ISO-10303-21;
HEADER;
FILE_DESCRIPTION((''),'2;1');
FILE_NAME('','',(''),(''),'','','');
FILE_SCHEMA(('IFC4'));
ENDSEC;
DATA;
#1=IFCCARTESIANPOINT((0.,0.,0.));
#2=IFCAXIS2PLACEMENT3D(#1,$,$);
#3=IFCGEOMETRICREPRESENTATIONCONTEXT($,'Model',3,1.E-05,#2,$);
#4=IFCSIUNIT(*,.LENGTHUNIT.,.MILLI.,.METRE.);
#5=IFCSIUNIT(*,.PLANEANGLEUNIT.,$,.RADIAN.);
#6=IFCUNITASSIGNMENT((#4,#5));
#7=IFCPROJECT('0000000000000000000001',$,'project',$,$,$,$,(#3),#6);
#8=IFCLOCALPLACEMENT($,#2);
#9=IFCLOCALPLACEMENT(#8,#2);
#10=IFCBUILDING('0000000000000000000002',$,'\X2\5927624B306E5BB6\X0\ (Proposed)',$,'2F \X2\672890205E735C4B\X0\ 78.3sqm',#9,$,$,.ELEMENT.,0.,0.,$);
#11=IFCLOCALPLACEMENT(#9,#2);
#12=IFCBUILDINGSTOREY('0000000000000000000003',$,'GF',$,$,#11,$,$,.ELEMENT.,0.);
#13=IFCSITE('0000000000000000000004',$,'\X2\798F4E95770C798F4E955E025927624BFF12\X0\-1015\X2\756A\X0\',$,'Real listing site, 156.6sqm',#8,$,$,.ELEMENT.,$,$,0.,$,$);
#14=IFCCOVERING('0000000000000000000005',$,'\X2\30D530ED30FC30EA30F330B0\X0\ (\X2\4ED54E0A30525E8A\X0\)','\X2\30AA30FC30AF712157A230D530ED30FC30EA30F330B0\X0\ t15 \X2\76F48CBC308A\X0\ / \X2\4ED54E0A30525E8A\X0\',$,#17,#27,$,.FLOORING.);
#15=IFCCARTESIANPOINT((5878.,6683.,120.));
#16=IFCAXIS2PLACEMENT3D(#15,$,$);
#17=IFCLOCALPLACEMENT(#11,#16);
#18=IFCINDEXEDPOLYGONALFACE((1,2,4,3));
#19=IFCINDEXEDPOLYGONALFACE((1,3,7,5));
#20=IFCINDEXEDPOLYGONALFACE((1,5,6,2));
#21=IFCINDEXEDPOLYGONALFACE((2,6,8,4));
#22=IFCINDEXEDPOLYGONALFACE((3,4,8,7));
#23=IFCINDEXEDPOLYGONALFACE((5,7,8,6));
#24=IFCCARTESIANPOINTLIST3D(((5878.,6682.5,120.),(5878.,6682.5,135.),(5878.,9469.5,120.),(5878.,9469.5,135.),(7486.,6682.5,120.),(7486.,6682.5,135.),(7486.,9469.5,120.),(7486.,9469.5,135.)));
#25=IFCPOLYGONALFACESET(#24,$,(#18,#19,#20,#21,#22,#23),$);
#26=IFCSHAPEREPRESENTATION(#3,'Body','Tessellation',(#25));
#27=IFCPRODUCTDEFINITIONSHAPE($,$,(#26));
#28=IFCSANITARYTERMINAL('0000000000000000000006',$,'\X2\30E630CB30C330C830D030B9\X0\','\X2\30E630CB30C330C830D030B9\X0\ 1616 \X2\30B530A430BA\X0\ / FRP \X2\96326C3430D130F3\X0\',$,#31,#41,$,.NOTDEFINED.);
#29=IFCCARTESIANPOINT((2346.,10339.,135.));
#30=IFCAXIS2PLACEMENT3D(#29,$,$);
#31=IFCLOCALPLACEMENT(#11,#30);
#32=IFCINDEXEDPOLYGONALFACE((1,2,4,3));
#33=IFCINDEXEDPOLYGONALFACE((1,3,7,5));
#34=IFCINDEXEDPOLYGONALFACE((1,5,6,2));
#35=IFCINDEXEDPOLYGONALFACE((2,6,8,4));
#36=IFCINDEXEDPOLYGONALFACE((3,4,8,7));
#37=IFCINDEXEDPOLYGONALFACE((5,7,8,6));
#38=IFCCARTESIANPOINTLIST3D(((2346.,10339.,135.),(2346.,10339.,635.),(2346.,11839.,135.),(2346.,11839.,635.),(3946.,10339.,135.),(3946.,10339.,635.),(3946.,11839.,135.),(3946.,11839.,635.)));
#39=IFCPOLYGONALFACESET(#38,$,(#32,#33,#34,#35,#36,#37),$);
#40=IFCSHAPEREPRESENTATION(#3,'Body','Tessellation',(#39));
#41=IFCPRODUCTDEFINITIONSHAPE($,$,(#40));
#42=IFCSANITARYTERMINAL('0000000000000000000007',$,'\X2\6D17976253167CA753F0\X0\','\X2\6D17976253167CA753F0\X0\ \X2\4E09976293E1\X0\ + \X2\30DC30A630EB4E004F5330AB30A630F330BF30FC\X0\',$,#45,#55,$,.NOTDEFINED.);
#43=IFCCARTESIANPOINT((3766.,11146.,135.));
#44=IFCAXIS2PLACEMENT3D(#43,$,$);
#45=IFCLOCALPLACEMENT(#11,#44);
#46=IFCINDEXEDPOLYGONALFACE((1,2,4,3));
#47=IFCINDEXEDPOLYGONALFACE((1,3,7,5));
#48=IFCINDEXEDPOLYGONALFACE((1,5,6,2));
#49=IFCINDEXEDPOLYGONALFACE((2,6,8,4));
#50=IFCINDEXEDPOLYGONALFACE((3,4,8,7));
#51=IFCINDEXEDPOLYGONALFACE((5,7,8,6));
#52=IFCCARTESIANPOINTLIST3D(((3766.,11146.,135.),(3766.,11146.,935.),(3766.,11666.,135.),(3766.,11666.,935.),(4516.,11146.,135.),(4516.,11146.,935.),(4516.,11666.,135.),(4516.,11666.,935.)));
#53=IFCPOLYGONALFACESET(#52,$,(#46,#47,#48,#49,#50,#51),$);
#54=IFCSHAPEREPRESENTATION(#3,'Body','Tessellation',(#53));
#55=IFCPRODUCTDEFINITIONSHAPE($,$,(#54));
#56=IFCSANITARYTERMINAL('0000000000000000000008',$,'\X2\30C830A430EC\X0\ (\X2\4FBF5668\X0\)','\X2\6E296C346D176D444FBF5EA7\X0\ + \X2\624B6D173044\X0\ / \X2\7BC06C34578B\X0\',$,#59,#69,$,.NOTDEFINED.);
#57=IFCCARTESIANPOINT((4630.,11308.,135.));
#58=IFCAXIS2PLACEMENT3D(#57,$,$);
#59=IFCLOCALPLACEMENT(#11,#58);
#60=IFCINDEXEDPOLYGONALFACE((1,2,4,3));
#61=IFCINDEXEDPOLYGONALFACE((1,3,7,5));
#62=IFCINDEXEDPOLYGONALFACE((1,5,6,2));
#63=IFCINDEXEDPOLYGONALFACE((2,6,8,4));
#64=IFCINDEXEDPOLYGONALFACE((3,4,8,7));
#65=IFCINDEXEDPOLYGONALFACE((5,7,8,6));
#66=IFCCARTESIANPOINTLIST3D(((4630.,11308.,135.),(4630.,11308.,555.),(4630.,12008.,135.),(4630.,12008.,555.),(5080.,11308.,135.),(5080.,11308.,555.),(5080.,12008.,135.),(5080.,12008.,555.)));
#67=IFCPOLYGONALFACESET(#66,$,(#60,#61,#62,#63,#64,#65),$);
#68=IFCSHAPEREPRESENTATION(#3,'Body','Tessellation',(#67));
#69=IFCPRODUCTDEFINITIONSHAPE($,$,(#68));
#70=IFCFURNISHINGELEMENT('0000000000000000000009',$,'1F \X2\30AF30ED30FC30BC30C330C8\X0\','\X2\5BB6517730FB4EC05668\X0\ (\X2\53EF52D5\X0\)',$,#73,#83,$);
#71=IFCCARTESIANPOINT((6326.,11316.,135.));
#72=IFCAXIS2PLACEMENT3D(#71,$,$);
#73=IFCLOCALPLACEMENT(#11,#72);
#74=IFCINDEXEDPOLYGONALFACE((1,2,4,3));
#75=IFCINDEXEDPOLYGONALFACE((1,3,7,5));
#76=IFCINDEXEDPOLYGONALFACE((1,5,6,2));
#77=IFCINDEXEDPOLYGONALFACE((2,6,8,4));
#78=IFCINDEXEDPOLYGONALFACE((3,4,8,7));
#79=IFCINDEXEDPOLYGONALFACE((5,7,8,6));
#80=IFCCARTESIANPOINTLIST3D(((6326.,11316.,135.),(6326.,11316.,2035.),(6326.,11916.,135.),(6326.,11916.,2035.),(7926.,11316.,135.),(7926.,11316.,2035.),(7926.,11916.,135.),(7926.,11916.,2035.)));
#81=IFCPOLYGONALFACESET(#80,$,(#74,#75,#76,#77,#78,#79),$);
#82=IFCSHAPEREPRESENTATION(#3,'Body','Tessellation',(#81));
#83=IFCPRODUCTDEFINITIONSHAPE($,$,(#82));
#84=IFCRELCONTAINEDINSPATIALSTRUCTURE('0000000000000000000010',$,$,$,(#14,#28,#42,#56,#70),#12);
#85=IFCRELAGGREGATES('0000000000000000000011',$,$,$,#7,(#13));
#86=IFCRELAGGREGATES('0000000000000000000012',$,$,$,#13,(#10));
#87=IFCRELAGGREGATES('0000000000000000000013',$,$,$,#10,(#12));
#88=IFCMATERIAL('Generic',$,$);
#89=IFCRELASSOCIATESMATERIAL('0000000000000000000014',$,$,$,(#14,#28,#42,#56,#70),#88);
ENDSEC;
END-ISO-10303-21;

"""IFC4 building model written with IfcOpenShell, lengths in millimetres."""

from ifc_helpers import new_model, si_unit, frame, frame_2d, origin, place, context, project, spatial, rectangle, extrude, material, element, save


model = new_model("IFC4")

# Units and contexts
model_context = context("Model", 3, precision=1e-05, world=origin())
ifc_project = project(units=[si_unit("LENGTHUNIT", "METRE", prefix="MILLI"), si_unit("PLANEANGLEUNIT", "RADIAN")], contexts=[model_context])

# Site, building, storey
site_placement = place(None, origin())
site = spatial("IfcSite", under=ifc_project, at=site_placement, Name="福井県福井市大手２-1015番", ObjectType="Real listing site, 156.6sqm", CompositionType="ELEMENT", RefElevation=0.0)
building_placement = place(site_placement, origin())
building = spatial("IfcBuilding", under=site, at=building_placement, Name="大手の家 (Proposed)", ObjectType="2F 木造平屋 78.3sqm", CompositionType="ELEMENT", ElevationOfRefHeight=0.0, ElevationOfTerrain=0.0)
storey_placement = place(building_placement, origin())
storey = spatial("IfcBuildingStorey", under=building, at=storey_placement, Name="GF", CompositionType="ELEMENT", Elevation=0.0)

# Covering
ifc_material_1 = material(Name="Generic")
covering_1_placement = place(storey_placement, frame((5878.0, 6683.0, 120.0)))
element("IfcCovering", 1, at=covering_1_placement, inside=storey, material=ifc_material_1, Name="フローリング (仕上げ床)", Description="オーク無垢フローリング t15 直貼り / 仕上げ床", PredefinedType="FLOORING", context=model_context, shape_type="SweptSolid", body=[
    extrude(rectangle(XDim=1608.0, YDim=2787.0, at=frame_2d((804.0, 1393.0))), frame((5878.0, 6683.0, 120.0)), (0.0, 0.0, 1.0), 15.0),
])

# Sanitary terminals
sanitary_terminal_1_placement = place(storey_placement, frame((2346.0, 10339.0, 135.0)))
element("IfcSanitaryTerminal", 2, at=sanitary_terminal_1_placement, inside=storey, material=ifc_material_1, Name="ユニットバス", Description="ユニットバス 1616 サイズ / FRP 防水パン", PredefinedType="NOTDEFINED", context=model_context, shape_type="SweptSolid", body=[
    extrude(rectangle(XDim=1600.0, YDim=1500.0, at=frame_2d((800.0, 750.0))), frame((2346.0, 10339.0, 135.0)), (0.0, 0.0, 1.0), 500.0),
])
sanitary_terminal_2_placement = place(storey_placement, frame((3766.0, 11146.0, 135.0)))
element("IfcSanitaryTerminal", 3, at=sanitary_terminal_2_placement, inside=storey, material=ifc_material_1, Name="洗面化粧台", Description="洗面化粧台 三面鏡 + ボウル一体カウンター", PredefinedType="NOTDEFINED", context=model_context, shape_type="SweptSolid", body=[
    extrude(rectangle(XDim=750.0, YDim=520.0, at=frame_2d((375.0, 260.0))), frame((3766.0, 11146.0, 135.0)), (0.0, 0.0, 1.0), 800.0),
])
sanitary_terminal_3_placement = place(storey_placement, frame((4630.0, 11308.0, 135.0)))
element("IfcSanitaryTerminal", 4, at=sanitary_terminal_3_placement, inside=storey, material=ifc_material_1, Name="トイレ (便器)", Description="温水洗浄便座 + 手洗い / 節水型", PredefinedType="NOTDEFINED", context=model_context, shape_type="SweptSolid", body=[
    extrude(rectangle(XDim=450.0, YDim=700.0, at=frame_2d((225.0, 350.0))), frame((4630.0, 11308.0, 135.0)), (0.0, 0.0, 1.0), 420.0),
])

# Furnishing element
furnishing_placement = place(storey_placement, frame((6326.0, 11316.0, 135.0)))
element("IfcFurnishingElement", 5, at=furnishing_placement, inside=storey, material=ifc_material_1, Name="1F クローゼット", Description="家具・什器 (可動)", context=model_context, shape_type="SweptSolid", body=[
    extrude(rectangle(XDim=1600.0, YDim=600.0, at=frame_2d((800.0, 300.0))), frame((6326.0, 11316.0, 135.0)), (0.0, 0.0, 1.0), 1900.0),
])

save(model, "model.ifc")
